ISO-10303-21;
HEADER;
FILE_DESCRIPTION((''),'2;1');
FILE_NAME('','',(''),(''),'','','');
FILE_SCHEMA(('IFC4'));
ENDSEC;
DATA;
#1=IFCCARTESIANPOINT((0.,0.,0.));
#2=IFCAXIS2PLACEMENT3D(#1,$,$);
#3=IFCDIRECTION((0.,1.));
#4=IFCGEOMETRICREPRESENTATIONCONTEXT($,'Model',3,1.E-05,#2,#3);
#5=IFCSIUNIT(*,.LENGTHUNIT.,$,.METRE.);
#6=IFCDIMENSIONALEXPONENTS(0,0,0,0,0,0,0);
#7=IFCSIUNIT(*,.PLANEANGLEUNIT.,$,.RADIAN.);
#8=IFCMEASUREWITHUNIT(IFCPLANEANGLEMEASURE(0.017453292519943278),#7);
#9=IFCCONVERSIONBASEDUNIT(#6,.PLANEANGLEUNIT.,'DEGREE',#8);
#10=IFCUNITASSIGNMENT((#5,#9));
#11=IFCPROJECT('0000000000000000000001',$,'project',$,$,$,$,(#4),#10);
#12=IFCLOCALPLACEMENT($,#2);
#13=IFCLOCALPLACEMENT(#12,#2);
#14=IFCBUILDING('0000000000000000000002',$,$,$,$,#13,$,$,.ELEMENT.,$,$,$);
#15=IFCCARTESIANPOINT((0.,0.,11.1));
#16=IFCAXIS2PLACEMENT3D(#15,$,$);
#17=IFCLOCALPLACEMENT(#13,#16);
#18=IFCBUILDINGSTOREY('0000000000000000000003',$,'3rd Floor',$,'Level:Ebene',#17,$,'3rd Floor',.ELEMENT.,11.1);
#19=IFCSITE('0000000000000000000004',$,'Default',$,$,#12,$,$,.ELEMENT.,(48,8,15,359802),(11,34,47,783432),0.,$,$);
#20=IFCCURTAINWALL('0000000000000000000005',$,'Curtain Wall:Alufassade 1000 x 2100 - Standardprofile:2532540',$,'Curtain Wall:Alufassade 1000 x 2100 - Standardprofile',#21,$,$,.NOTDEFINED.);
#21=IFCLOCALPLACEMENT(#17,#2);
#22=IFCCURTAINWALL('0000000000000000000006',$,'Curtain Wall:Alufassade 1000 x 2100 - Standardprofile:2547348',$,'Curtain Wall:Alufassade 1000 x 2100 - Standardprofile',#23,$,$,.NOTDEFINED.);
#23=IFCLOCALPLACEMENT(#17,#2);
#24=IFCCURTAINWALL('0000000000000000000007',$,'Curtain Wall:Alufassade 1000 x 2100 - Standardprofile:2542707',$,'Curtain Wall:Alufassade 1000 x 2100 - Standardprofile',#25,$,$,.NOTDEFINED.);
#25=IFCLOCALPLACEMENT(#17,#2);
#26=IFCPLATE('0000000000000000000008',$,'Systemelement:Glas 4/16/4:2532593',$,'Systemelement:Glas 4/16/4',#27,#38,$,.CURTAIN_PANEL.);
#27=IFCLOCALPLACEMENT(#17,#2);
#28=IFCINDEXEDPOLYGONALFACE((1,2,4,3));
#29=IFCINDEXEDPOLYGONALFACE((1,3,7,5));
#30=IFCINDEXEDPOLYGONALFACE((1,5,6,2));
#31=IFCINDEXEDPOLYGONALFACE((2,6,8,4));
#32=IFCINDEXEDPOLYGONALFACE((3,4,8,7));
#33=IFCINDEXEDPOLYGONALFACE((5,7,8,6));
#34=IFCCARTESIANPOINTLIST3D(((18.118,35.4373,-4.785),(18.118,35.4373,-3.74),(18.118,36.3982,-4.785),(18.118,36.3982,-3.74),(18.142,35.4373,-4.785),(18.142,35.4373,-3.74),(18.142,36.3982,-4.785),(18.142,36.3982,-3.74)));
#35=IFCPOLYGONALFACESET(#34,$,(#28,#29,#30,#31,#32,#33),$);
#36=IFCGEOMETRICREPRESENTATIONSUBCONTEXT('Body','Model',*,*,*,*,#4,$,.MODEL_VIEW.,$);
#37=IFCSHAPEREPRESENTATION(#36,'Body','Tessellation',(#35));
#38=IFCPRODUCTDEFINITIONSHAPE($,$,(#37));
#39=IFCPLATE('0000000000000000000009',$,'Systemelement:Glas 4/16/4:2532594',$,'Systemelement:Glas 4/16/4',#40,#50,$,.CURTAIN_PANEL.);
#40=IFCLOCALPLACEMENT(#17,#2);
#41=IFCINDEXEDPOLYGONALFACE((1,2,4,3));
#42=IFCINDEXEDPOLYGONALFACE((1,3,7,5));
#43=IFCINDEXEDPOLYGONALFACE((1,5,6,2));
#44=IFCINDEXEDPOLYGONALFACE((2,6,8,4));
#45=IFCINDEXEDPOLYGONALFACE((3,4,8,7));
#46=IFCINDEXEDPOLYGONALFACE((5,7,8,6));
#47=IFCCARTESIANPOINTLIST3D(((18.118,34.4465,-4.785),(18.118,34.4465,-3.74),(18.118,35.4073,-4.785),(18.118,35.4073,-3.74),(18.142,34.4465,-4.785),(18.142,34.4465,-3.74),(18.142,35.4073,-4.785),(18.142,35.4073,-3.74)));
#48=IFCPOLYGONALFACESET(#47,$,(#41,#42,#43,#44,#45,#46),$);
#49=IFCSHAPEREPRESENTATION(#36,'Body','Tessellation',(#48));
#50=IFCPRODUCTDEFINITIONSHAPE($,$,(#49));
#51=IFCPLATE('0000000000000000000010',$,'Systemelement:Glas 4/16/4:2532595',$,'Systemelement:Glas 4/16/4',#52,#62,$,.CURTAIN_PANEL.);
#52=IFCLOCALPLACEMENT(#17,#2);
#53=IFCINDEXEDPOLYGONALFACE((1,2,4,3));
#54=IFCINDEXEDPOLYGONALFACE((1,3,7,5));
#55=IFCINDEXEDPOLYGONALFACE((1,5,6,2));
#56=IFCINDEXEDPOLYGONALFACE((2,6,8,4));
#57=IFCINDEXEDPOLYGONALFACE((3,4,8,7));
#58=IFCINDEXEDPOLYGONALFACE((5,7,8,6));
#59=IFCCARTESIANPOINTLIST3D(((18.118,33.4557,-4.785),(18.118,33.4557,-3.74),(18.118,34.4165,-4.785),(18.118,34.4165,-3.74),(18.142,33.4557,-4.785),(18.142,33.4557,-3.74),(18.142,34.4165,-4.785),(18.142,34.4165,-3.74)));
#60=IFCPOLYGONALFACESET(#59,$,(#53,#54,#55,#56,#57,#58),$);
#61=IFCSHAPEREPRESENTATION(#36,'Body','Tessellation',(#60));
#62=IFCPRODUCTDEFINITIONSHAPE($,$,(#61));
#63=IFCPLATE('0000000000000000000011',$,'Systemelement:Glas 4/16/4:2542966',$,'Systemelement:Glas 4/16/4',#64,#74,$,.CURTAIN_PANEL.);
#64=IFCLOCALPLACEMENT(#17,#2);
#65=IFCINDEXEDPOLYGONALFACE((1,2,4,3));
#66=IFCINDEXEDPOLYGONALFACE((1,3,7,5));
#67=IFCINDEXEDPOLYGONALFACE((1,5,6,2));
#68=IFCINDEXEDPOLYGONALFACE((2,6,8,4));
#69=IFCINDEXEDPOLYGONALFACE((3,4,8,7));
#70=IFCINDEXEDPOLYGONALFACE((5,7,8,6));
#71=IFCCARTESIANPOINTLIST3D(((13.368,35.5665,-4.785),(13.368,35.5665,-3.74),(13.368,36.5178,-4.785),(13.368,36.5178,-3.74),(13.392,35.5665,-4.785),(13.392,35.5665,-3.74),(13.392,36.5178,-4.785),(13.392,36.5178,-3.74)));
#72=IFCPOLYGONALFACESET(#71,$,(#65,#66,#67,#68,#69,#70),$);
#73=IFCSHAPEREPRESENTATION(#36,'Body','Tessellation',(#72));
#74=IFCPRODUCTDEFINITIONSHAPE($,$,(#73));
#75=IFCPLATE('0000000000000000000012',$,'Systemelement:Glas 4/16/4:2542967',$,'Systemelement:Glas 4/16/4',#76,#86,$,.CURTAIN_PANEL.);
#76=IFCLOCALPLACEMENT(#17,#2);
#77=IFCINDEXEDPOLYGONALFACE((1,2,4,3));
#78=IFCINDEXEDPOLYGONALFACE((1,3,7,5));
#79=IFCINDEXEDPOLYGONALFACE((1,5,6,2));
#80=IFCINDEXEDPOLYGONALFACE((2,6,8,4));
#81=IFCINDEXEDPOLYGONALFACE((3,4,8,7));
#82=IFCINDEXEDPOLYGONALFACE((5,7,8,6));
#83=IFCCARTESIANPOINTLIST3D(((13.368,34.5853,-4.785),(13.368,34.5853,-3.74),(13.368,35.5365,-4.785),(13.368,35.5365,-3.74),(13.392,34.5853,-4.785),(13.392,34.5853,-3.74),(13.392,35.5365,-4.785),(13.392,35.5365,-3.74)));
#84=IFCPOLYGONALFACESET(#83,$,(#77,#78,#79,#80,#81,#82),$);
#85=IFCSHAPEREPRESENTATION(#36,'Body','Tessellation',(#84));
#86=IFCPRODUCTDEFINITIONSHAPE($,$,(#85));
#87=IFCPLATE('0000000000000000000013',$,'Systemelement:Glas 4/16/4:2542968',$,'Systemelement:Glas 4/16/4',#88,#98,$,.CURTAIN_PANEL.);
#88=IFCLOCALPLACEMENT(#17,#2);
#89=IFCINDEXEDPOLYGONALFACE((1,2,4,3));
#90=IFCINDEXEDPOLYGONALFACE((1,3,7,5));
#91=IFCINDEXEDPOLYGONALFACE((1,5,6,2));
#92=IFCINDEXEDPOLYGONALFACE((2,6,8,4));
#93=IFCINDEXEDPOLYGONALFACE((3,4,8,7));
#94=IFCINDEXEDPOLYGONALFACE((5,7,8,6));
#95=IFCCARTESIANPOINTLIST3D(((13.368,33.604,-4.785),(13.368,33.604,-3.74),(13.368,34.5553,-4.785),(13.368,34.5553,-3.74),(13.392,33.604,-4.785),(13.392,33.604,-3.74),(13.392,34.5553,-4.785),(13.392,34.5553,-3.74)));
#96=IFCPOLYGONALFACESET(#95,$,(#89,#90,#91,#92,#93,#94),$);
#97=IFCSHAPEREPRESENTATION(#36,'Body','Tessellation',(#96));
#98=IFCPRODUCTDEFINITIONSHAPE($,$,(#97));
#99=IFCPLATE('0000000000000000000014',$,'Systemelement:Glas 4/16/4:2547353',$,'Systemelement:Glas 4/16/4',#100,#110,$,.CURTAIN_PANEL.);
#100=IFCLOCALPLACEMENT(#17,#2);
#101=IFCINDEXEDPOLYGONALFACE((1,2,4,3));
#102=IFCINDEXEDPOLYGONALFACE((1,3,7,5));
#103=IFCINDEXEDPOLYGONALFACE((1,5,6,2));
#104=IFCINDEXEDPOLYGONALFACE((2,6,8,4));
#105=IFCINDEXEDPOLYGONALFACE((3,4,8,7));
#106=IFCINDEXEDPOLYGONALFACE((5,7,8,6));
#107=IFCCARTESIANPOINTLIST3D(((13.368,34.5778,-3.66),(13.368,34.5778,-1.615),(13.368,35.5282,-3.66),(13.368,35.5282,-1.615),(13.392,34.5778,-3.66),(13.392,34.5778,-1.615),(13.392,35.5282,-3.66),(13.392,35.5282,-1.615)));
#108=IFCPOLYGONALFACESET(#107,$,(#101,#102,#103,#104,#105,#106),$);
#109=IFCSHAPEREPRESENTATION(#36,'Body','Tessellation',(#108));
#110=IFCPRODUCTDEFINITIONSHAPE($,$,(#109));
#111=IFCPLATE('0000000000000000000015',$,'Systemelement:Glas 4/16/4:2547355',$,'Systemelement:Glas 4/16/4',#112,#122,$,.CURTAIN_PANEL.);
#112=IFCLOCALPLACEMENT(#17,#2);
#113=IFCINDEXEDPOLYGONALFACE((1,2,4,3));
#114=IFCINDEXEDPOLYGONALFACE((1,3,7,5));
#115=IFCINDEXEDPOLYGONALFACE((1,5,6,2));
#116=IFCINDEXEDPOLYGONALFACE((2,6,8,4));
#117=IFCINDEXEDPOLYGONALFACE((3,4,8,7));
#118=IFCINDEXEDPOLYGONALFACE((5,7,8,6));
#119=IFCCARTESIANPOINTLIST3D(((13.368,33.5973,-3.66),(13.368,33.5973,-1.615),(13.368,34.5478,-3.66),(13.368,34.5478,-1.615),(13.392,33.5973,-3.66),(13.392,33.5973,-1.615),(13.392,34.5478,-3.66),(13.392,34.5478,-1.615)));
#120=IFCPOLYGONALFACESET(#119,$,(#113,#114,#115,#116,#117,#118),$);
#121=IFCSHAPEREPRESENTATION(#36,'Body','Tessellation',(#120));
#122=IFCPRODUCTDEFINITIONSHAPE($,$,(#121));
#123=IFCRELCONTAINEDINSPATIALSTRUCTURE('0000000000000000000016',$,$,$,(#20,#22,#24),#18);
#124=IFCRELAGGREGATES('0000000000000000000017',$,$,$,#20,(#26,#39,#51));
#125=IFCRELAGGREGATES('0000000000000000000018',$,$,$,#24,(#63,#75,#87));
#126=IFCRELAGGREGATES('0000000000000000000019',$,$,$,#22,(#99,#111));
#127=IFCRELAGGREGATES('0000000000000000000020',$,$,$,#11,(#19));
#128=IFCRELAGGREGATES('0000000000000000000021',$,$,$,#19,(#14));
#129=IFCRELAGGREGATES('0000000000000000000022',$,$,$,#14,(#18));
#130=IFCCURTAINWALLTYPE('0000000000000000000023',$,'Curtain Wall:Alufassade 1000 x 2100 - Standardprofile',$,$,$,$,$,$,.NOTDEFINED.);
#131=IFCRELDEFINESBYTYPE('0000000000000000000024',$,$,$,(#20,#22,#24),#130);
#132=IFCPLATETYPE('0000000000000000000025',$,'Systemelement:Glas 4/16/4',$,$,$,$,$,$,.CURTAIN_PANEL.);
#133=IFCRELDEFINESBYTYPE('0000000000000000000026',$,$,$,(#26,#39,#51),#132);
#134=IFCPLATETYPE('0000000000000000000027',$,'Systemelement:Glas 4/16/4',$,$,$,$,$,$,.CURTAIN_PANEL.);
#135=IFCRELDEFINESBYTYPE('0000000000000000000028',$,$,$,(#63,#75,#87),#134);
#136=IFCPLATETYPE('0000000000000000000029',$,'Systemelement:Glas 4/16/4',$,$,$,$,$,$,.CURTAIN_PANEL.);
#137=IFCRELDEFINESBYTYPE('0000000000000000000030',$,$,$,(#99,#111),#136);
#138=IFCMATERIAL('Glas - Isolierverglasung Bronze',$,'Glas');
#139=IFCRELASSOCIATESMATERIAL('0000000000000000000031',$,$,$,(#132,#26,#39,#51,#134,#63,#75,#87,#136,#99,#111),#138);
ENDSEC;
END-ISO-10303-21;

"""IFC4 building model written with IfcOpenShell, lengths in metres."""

from ifc_helpers import new_model, entity, si_unit, converted_unit, direction, frame, origin, place, context, subcontext, project, spatial, indexed_curve, outline, extrude, source, transform, mapped, material, type_object, type_shapes, element, aggregate, save


model = new_model("IFC4")

# Units and contexts
model_context = context("Model", 3, precision=1e-05, world=origin(), true_north=direction((0.0, 1.0)))
body_context = subcontext(model_context, "Body", "Model", "MODEL_VIEW")
ifc_project = project(units=[si_unit("LENGTHUNIT", "METRE"), converted_unit("PLANEANGLEUNIT", "DEGREE", entity("IfcPlaneAngleMeasure", 0.017453292519943278), si_unit("PLANEANGLEUNIT", "RADIAN"), dimensions=[0, 0, 0, 0, 0, 0, 0])], contexts=[model_context])

# Site, building, storey
site_placement = place(None, origin())
site = spatial("IfcSite", under=ifc_project, at=site_placement, Name="Default", CompositionType="ELEMENT", RefLatitude=(48, 8, 15, 359802), RefLongitude=(11, 34, 47, 783432), RefElevation=0.0)
building_placement = place(site_placement, origin())
building = spatial("IfcBuilding", under=site, at=building_placement, CompositionType="ELEMENT")
storey_placement = place(building_placement, frame((0.0, 0.0, 11.1)))
storey = spatial("IfcBuildingStorey", under=building, at=storey_placement, Name="3rd Floor", ObjectType="Level:Ebene", LongName="3rd Floor", CompositionType="ELEMENT", Elevation=11.1)

# Curtain walls
curtain_wall_type = type_object("IfcCurtainWallType", Name="Curtain Wall:Alufassade 1000 x 2100 - Standardprofile", PredefinedType="NOTDEFINED")
curtain_wall_1_placement = place(storey_placement, frame((0.0, 0.0, -11.1)))
curtain_wall_1 = element("IfcCurtainWall", 1, at=curtain_wall_1_placement, inside=storey, type_object=curtain_wall_type, Name="Curtain Wall:Alufassade 1000 x 2100 - Standardprofile:2532540", ObjectType="Curtain Wall:Alufassade 1000 x 2100 - Standardprofile", PredefinedType="NOTDEFINED")
curtain_wall_2_placement = place(storey_placement, frame((0.0, 0.0, -11.1)))
curtain_wall_2 = element("IfcCurtainWall", 2, at=curtain_wall_2_placement, inside=storey, type_object=curtain_wall_type, Name="Curtain Wall:Alufassade 1000 x 2100 - Standardprofile:2547348", ObjectType="Curtain Wall:Alufassade 1000 x 2100 - Standardprofile", PredefinedType="NOTDEFINED")

# Curtain wall
curtain_wall_3_placement = place(storey_placement, frame((0.0, 0.0, -11.1)))
curtain_wall_3 = element("IfcCurtainWall", 3, at=curtain_wall_3_placement, inside=storey, type_object=curtain_wall_type, Name="Curtain Wall:Alufassade 1000 x 2100 - Standardprofile:2542707", ObjectType="Curtain Wall:Alufassade 1000 x 2100 - Standardprofile", PredefinedType="NOTDEFINED")

# Plates
ifc_material_1 = material(Name="Glas - Isolierverglasung Bronze", Category="Glas")
plate_type_1 = type_object("IfcPlateType", Name="Systemelement:Glas 4/16/4", PredefinedType="CURTAIN_PANEL", material=ifc_material_1)
shared_shape_1 = source(origin(), body_context, "Body", "SweptSolid", [
    extrude(outline(indexed_curve([(-0.012, -0.4804), (0.012, -0.4804), (0.012, 0.4804), (-0.012, 0.4804), (-0.012, -0.4804)], self_intersect=False)), frame((0.0, 0.0, 0.0), z_axis=(0.0, 0.0, 1.0), x_axis=(0.0, 1.0, 0.0)), (0.0, 0.0, 1.0), 1.045),
])
type_shapes(plate_type_1, [shared_shape_1])
plate_1_placement = place(curtain_wall_1_placement, frame((18.13, 35.9178, 6.315), z_axis=(0.0, 0.0, 1.0), x_axis=(0.0, -1.0, 0.0)))
plate_1 = element("IfcPlate", 4, at=plate_1_placement, type_object=plate_type_1, material=ifc_material_1, Name="Systemelement:Glas 4/16/4:2532593", ObjectType="Systemelement:Glas 4/16/4", PredefinedType="CURTAIN_PANEL", context=body_context, shape_type="MappedRepresentation", body=[
    mapped(shared_shape_1, transform((0.0, 0.0, 0.0), scale=1.0)),
])
plate_2_placement = place(curtain_wall_1_placement, frame((18.13, 34.9269, 6.315), z_axis=(0.0, 0.0, 1.0), x_axis=(0.0, -1.0, 0.0)))
plate_2 = element("IfcPlate", 5, at=plate_2_placement, type_object=plate_type_1, material=ifc_material_1, Name="Systemelement:Glas 4/16/4:2532594", ObjectType="Systemelement:Glas 4/16/4", PredefinedType="CURTAIN_PANEL", context=body_context, shape_type="MappedRepresentation", body=[
    mapped(shared_shape_1, transform((0.0, 0.0, 0.0), scale=1.0)),
])
plate_3_placement = place(curtain_wall_1_placement, frame((18.13, 33.9361, 6.315), z_axis=(0.0, 0.0, 1.0), x_axis=(0.0, -1.0, 0.0)))
plate_3 = element("IfcPlate", 6, at=plate_3_placement, type_object=plate_type_1, material=ifc_material_1, Name="Systemelement:Glas 4/16/4:2532595", ObjectType="Systemelement:Glas 4/16/4", PredefinedType="CURTAIN_PANEL", context=body_context, shape_type="MappedRepresentation", body=[
    mapped(shared_shape_1, transform((0.0, 0.0, 0.0), scale=1.0)),
])
aggregate(curtain_wall_1, [plate_1, plate_2, plate_3])
plate_type_2 = type_object("IfcPlateType", Name="Systemelement:Glas 4/16/4", PredefinedType="CURTAIN_PANEL", material=ifc_material_1)
shared_shape_2 = source(origin(), body_context, "Body", "SweptSolid", [
    extrude(outline(indexed_curve([(-0.012, -0.4756), (0.012, -0.4756), (0.012, 0.4756), (-0.012, 0.4756), (-0.012, -0.4756)], self_intersect=False)), frame((0.0, 0.0, 0.0), z_axis=(0.0, 0.0, 1.0), x_axis=(0.0, 1.0, 0.0)), (0.0, 0.0, 1.0), 1.045),
])
type_shapes(plate_type_2, [shared_shape_2])
plate_4_placement = place(curtain_wall_3_placement, frame((13.38, 36.0421, 6.315), z_axis=(0.0, 0.0, 1.0), x_axis=(0.0, -1.0, 0.0)))
plate_4 = element("IfcPlate", 7, at=plate_4_placement, type_object=plate_type_2, material=ifc_material_1, Name="Systemelement:Glas 4/16/4:2542966", ObjectType="Systemelement:Glas 4/16/4", PredefinedType="CURTAIN_PANEL", context=body_context, shape_type="MappedRepresentation", body=[
    mapped(shared_shape_2, transform((0.0, 0.0, 0.0), scale=1.0)),
])
plate_5_placement = place(curtain_wall_3_placement, frame((13.38, 35.0609, 6.315), z_axis=(0.0, 0.0, 1.0), x_axis=(0.0, -1.0, 0.0)))
plate_5 = element("IfcPlate", 8, at=plate_5_placement, type_object=plate_type_2, material=ifc_material_1, Name="Systemelement:Glas 4/16/4:2542967", ObjectType="Systemelement:Glas 4/16/4", PredefinedType="CURTAIN_PANEL", context=body_context, shape_type="MappedRepresentation", body=[
    mapped(shared_shape_2, transform((0.0, 0.0, 0.0), scale=1.0)),
])
plate_6_placement = place(curtain_wall_3_placement, frame((13.38, 34.0796, 6.315), z_axis=(0.0, 0.0, 1.0), x_axis=(0.0, -1.0, 0.0)))
plate_6 = element("IfcPlate", 9, at=plate_6_placement, type_object=plate_type_2, material=ifc_material_1, Name="Systemelement:Glas 4/16/4:2542968", ObjectType="Systemelement:Glas 4/16/4", PredefinedType="CURTAIN_PANEL", context=body_context, shape_type="MappedRepresentation", body=[
    mapped(shared_shape_2, transform((0.0, 0.0, 0.0), scale=1.0)),
])
aggregate(curtain_wall_3, [plate_4, plate_5, plate_6])
plate_type_3 = type_object("IfcPlateType", Name="Systemelement:Glas 4/16/4", PredefinedType="CURTAIN_PANEL", material=ifc_material_1)
shared_shape_3 = source(origin(), body_context, "Body", "SweptSolid", [
    extrude(outline(indexed_curve([(-0.012, -0.4752), (0.012, -0.4752), (0.012, 0.4752), (-0.012, 0.4752), (-0.012, -0.4752)], self_intersect=False)), frame((0.0, 0.0, 0.0), z_axis=(0.0, 0.0, 1.0), x_axis=(0.0, 1.0, 0.0)), (0.0, 0.0, 1.0), 2.045),
])
type_shapes(plate_type_3, [shared_shape_3])
plate_7_placement = place(curtain_wall_2_placement, frame((13.38, 35.053, 7.44), z_axis=(0.0, 0.0, 1.0), x_axis=(0.0, -1.0, 0.0)))
plate_7 = element("IfcPlate", 10, at=plate_7_placement, type_object=plate_type_3, material=ifc_material_1, Name="Systemelement:Glas 4/16/4:2547353", ObjectType="Systemelement:Glas 4/16/4", PredefinedType="CURTAIN_PANEL", context=body_context, shape_type="MappedRepresentation", body=[
    mapped(shared_shape_3, transform((0.0, 0.0, 0.0), scale=1.0)),
])
plate_8_placement = place(curtain_wall_2_placement, frame((13.38, 34.0725, 7.44), z_axis=(0.0, 0.0, 1.0), x_axis=(0.0, -1.0, 0.0)))
plate_8 = element("IfcPlate", 11, at=plate_8_placement, type_object=plate_type_3, material=ifc_material_1, Name="Systemelement:Glas 4/16/4:2547355", ObjectType="Systemelement:Glas 4/16/4", PredefinedType="CURTAIN_PANEL", context=body_context, shape_type="MappedRepresentation", body=[
    mapped(shared_shape_3, transform((0.0, 0.0, 0.0), scale=1.0)),
])
aggregate(curtain_wall_2, [plate_7, plate_8])

save(model, "model.ifc")
